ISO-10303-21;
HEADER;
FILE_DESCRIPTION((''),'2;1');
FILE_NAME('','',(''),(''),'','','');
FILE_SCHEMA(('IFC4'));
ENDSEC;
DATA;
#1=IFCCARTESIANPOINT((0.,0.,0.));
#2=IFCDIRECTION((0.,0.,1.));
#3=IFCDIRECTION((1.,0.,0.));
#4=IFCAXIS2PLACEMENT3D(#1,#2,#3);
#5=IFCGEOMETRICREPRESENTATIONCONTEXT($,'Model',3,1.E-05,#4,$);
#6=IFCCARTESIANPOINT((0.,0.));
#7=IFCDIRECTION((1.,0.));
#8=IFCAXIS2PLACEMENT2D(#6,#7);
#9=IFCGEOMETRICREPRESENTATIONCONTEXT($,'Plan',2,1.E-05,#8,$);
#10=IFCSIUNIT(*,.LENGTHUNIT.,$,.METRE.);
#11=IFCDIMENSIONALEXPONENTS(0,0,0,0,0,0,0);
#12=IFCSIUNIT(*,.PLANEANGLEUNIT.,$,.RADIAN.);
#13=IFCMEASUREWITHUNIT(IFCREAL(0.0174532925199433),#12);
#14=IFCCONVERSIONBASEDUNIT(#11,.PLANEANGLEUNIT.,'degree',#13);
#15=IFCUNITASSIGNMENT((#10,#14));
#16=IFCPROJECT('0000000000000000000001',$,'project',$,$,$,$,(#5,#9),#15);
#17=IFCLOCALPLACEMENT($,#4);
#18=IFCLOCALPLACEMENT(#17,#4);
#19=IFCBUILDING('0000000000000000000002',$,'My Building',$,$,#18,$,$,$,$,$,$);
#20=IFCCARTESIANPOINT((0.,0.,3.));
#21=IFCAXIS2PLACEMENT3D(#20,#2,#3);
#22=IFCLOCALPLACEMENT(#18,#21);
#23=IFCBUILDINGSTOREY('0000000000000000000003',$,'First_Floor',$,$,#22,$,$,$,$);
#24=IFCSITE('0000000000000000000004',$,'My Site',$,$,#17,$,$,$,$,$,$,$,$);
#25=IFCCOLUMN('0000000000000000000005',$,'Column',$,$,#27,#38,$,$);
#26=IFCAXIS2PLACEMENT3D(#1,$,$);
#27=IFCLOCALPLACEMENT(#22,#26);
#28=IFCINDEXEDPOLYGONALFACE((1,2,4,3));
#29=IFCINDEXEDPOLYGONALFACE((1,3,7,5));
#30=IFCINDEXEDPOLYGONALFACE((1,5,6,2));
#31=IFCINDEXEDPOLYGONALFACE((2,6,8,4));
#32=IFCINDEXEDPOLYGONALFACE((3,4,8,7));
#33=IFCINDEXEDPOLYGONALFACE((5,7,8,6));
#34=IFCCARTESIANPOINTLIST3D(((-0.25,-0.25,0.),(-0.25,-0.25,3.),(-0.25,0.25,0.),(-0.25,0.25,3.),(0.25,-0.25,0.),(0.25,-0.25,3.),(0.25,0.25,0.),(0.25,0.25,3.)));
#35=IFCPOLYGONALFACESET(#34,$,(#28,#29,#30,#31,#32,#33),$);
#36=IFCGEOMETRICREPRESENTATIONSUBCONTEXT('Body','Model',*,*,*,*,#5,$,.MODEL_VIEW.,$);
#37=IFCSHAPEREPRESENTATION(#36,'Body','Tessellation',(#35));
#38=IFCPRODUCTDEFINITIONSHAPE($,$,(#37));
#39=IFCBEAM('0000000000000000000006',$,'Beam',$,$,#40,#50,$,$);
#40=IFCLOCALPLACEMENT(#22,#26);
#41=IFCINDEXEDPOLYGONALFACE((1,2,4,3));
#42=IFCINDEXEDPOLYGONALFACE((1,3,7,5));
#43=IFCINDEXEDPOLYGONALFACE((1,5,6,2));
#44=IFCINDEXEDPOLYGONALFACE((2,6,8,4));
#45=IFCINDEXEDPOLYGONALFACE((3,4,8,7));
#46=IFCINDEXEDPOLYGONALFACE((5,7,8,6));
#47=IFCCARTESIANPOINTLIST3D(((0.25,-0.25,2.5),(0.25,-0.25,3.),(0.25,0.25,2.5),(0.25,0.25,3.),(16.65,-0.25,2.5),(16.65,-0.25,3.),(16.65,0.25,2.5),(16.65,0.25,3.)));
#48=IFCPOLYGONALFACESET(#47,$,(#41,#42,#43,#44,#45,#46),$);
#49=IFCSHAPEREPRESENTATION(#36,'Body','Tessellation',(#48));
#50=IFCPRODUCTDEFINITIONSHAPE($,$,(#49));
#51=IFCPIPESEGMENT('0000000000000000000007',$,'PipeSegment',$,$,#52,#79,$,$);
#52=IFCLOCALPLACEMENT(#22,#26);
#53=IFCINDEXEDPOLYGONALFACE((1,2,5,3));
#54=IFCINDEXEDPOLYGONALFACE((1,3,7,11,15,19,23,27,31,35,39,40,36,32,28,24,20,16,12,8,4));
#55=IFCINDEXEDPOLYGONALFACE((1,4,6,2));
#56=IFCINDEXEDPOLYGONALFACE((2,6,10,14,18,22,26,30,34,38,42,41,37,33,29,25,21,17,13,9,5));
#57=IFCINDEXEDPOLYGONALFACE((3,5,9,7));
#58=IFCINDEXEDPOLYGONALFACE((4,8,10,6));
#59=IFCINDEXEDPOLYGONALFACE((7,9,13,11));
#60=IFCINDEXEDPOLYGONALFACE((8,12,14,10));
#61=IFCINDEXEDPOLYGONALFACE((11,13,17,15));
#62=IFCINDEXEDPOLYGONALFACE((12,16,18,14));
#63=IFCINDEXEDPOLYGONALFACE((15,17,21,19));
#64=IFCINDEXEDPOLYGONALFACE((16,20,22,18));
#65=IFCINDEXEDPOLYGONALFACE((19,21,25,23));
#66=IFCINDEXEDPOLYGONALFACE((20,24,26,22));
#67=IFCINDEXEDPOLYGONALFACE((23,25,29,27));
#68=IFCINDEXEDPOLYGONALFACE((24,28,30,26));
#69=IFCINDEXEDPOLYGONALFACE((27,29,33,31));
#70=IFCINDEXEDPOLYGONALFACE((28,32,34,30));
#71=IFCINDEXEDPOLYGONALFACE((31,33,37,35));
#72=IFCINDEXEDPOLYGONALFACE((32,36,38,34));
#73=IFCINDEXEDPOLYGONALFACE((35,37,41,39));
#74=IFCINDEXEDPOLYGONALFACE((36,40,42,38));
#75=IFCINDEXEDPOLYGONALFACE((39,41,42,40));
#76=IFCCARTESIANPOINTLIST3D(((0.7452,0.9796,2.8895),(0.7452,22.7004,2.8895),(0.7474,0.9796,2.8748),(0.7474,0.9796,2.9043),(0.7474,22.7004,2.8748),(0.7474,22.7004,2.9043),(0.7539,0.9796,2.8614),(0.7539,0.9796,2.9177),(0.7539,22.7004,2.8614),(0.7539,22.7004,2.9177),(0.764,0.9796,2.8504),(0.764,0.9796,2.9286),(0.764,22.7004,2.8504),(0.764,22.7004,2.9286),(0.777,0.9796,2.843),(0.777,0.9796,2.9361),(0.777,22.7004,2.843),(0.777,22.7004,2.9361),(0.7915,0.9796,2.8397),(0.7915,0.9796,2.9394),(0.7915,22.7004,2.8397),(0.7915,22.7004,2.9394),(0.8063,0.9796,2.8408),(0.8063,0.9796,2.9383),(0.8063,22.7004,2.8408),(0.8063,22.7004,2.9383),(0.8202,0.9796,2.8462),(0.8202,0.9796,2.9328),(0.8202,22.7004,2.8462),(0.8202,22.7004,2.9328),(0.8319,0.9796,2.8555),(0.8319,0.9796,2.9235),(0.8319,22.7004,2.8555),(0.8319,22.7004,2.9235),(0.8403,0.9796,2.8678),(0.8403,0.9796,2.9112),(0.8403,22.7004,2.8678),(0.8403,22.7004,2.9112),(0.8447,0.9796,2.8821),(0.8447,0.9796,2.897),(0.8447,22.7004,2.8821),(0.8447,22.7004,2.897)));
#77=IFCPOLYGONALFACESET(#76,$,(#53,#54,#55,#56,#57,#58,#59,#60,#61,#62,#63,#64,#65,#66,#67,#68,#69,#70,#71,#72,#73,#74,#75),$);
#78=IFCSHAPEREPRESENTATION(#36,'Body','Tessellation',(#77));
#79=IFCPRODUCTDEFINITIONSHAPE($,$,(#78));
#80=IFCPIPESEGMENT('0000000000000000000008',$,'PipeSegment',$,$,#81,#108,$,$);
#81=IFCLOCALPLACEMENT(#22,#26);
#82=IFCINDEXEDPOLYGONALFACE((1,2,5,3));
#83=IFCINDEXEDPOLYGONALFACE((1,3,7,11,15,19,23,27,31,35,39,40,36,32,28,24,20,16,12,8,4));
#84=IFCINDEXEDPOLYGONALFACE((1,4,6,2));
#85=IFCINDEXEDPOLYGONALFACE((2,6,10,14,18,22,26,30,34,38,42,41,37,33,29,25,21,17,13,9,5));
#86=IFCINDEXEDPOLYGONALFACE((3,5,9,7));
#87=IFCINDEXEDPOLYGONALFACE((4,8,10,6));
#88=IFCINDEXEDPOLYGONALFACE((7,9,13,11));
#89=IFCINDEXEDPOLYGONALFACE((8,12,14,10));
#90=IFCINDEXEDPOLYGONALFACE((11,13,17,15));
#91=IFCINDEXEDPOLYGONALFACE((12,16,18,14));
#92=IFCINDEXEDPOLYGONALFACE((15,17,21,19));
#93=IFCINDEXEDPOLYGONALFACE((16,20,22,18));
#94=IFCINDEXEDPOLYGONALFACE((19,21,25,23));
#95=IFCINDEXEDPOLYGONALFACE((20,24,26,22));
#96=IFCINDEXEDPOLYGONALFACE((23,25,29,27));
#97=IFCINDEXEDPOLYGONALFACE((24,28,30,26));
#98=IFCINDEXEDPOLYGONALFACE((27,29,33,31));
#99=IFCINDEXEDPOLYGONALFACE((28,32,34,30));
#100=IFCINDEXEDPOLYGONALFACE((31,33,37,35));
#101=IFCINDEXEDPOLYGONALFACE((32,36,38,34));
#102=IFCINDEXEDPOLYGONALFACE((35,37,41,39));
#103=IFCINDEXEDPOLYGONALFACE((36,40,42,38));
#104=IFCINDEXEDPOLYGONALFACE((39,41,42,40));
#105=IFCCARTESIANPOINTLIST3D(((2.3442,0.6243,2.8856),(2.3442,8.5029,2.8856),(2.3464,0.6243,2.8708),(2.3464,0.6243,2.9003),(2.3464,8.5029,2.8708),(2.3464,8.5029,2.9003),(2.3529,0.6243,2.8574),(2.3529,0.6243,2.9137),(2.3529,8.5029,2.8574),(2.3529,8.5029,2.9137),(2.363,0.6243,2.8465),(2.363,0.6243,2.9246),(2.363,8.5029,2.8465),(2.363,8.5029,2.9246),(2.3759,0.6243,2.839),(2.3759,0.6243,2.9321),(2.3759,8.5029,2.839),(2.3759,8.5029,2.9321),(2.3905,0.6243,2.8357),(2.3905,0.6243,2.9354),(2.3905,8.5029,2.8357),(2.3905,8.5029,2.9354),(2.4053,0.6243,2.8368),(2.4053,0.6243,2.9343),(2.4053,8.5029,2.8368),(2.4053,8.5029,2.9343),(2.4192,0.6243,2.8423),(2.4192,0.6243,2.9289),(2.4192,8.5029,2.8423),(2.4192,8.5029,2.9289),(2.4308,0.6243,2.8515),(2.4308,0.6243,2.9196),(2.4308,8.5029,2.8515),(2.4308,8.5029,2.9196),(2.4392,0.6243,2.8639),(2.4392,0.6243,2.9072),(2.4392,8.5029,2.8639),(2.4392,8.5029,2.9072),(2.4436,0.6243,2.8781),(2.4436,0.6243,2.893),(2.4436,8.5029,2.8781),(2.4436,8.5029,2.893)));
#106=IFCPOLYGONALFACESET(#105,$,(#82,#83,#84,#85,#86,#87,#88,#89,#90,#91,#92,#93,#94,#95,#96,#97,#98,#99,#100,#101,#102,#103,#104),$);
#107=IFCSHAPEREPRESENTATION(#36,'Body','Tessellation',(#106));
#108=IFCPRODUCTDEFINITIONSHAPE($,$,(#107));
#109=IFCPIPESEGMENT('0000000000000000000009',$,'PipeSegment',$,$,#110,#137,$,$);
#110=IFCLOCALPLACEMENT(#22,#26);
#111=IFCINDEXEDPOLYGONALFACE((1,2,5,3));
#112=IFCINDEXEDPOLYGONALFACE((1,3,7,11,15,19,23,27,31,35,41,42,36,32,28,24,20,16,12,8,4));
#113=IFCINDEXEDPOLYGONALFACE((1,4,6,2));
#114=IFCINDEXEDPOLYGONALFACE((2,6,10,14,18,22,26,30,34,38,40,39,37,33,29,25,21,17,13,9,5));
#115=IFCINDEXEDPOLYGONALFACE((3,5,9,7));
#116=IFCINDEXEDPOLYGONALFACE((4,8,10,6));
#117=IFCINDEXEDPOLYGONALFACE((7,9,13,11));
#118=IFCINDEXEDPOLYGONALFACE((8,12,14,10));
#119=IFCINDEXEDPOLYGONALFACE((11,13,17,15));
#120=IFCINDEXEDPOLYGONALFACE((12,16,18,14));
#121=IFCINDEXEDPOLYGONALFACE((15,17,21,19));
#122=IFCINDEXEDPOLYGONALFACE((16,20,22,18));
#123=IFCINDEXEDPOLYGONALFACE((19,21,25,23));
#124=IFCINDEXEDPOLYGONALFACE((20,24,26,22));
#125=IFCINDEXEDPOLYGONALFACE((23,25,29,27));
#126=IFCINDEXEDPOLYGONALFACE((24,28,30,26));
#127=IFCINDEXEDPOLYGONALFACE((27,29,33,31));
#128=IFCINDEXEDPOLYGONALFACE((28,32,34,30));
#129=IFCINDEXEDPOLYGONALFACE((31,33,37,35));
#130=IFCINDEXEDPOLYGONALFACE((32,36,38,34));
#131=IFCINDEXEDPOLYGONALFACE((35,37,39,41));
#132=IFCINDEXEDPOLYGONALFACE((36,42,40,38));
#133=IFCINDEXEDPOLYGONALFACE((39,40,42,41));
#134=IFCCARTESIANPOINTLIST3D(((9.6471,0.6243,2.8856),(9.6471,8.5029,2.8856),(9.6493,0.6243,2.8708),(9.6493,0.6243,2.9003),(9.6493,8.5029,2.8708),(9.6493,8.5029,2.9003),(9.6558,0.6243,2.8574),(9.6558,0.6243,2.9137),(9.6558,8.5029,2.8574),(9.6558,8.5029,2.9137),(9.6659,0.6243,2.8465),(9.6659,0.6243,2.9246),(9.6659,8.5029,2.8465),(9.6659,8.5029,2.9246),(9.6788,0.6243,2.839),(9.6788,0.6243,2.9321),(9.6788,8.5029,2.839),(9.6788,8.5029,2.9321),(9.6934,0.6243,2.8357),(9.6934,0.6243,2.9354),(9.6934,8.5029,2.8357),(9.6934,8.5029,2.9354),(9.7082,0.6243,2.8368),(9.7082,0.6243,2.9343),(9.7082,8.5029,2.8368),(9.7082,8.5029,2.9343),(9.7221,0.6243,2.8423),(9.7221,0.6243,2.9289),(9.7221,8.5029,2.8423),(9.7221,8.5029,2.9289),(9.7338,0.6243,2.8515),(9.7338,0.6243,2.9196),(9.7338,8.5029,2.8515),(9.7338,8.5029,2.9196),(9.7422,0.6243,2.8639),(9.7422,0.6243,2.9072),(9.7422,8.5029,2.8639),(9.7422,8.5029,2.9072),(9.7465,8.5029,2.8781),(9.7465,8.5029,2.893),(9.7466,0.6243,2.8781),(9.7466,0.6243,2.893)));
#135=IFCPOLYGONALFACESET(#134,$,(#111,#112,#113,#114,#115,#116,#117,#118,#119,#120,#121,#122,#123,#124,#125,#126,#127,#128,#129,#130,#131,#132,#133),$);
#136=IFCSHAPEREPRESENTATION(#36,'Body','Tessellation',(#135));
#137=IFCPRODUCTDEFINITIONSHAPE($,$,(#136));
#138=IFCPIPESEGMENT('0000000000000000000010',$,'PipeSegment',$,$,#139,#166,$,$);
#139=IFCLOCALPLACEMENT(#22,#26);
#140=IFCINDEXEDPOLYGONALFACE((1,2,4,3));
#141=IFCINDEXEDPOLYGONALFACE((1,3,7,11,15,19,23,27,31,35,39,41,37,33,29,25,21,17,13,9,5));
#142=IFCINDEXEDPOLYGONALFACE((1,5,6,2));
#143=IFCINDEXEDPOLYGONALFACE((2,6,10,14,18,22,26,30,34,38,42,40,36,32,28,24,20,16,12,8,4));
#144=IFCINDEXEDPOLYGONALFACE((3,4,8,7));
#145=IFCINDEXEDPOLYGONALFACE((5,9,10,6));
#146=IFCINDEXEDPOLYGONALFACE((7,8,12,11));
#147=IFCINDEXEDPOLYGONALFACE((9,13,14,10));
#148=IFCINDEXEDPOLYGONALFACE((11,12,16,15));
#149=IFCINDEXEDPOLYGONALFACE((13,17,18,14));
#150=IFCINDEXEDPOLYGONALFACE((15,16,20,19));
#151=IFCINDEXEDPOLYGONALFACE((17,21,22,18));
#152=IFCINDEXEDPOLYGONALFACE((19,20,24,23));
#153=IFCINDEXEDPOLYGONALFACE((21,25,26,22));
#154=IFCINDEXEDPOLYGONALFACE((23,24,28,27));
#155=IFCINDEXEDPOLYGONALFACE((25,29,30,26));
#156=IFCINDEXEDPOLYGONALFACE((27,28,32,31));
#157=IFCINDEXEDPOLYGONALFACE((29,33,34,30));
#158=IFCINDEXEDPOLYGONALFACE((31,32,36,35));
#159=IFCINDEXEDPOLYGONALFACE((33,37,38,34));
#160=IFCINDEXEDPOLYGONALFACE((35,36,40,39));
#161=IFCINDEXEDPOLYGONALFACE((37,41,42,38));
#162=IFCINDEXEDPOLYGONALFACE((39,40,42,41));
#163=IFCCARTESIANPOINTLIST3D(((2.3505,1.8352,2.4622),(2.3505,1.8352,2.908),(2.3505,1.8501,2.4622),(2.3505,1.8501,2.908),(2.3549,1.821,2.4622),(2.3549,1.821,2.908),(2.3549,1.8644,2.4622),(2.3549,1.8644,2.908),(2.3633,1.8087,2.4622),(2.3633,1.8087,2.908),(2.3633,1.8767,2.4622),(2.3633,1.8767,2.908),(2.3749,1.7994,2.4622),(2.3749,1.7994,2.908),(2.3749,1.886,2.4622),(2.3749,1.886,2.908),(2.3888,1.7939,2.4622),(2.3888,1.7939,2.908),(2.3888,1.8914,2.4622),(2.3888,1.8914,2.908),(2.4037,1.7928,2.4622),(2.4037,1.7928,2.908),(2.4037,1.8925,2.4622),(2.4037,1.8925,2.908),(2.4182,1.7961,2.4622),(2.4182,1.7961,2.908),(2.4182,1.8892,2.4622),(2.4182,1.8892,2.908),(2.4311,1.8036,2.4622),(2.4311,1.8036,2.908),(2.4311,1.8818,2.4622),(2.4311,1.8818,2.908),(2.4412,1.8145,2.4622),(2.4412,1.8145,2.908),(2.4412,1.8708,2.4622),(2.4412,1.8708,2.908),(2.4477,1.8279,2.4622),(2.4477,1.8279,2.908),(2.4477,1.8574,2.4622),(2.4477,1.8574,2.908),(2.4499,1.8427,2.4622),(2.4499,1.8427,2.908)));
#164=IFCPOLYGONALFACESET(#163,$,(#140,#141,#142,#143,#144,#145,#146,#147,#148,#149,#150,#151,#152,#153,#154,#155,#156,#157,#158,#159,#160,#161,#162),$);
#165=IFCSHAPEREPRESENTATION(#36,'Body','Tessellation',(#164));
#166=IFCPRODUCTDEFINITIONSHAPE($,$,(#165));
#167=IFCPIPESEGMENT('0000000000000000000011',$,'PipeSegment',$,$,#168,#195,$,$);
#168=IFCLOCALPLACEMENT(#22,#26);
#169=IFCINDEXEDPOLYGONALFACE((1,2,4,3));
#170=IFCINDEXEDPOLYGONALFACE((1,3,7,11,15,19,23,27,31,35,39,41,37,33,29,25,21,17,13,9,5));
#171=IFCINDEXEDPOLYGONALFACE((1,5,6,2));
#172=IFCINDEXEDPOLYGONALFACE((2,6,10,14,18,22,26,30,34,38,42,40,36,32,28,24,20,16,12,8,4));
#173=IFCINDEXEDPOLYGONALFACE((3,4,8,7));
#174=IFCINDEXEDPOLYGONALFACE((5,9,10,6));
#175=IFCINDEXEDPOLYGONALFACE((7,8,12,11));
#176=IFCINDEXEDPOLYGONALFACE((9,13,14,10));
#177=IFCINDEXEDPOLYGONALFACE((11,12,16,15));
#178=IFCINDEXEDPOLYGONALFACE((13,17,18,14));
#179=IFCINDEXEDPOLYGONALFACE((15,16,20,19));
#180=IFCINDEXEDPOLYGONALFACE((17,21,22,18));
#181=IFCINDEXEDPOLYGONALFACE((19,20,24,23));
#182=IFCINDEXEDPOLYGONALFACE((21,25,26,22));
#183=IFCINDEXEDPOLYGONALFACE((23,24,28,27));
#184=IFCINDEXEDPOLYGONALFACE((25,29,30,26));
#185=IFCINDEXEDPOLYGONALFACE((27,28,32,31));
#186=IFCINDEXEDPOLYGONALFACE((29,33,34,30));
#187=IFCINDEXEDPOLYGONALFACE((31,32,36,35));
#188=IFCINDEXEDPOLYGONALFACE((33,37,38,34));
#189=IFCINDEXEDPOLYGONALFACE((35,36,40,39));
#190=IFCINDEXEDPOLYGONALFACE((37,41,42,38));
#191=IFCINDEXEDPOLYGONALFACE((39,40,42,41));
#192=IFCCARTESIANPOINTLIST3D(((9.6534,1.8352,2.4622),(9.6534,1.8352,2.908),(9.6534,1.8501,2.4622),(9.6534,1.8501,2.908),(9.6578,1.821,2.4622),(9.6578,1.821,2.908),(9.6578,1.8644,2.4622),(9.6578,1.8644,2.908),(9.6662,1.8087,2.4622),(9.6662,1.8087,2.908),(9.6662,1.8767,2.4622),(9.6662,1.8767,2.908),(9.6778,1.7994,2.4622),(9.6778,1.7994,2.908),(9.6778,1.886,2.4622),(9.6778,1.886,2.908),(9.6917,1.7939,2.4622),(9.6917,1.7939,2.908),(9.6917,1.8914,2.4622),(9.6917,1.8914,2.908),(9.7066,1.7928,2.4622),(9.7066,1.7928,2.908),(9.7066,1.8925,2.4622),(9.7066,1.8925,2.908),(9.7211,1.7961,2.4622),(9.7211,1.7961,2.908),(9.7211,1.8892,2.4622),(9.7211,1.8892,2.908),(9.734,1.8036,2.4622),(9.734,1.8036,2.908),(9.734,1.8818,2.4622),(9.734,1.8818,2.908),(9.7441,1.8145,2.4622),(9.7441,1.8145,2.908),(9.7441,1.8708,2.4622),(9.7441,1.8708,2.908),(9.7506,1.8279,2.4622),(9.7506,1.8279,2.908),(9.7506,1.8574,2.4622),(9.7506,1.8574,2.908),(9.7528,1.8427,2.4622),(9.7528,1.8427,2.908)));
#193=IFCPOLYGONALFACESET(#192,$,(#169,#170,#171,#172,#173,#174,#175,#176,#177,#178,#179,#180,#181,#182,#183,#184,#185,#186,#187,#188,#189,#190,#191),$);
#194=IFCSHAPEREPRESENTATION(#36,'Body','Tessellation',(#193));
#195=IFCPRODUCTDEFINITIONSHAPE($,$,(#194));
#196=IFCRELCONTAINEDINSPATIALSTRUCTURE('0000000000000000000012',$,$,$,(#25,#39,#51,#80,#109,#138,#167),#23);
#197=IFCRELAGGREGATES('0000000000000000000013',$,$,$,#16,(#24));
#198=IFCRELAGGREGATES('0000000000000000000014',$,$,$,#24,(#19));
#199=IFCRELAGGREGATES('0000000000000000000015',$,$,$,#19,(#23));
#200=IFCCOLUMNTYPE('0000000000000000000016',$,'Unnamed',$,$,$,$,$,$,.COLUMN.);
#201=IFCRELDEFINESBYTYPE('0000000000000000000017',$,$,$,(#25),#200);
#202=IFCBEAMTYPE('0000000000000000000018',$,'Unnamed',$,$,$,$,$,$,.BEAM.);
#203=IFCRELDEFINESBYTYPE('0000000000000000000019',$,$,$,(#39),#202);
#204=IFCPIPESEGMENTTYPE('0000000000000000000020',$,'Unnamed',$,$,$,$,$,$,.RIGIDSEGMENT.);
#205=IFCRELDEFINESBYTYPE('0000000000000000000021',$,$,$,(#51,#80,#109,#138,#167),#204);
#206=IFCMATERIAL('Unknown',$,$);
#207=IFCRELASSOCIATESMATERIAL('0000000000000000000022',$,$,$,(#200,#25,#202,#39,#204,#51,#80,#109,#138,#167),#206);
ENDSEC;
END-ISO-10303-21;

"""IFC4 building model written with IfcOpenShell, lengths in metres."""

from ifc_helpers import new_model, entity, si_unit, converted_unit, frame, origin_with_axes, origin_2d_with_axis, place, context, subcontext, project, spatial, rectangle, circle, extrude, material, material_profile, profile_set, profile_usage, type_object, element, save


model = new_model("IFC4")

# Units and contexts
model_context = context("Model", 3, precision=1e-05, world=origin_with_axes())
plan_context = context("Plan", 2, precision=1e-05, world=origin_2d_with_axis())
body_context = subcontext(model_context, "Body", "Model", "MODEL_VIEW")
ifc_project = project(units=[si_unit("LENGTHUNIT", "METRE"), converted_unit("PLANEANGLEUNIT", "degree", entity("IfcReal", 0.0174532925199433), si_unit("PLANEANGLEUNIT", "RADIAN"), dimensions=[0, 0, 0, 0, 0, 0, 0])], contexts=[model_context, plan_context])

# Site, building, storey
site_placement = place(None, origin_with_axes())
site = spatial("IfcSite", under=ifc_project, at=site_placement, Name="My Site")
building_placement = place(site_placement, origin_with_axes())
building = spatial("IfcBuilding", under=site, at=building_placement, Name="My Building")
storey_placement = place(building_placement, frame((0.0, 0.0, 3.0), z_axis=(0.0, 0.0, 1.0), x_axis=(1.0, 0.0, 0.0)))
storey = spatial("IfcBuildingStorey", under=building, at=storey_placement, Name="First_Floor")

# Column
ifc_material = material(Name="Unknown")
ifc_material_profile_1 = material_profile(ifc_material, rectangle(XDim=0.5, YDim=0.5))
ifc_profile_set_1 = profile_set([ifc_material_profile_1])
ifc_profile_usage_1 = profile_usage(ifc_profile_set_1, cardinal=5)
column_type = type_object("IfcColumnType", Name="Unnamed", PredefinedType="COLUMN", material=ifc_profile_set_1)
column_placement = place(storey_placement, frame((0.0, 0.0, 0.0), z_axis=(0.0, 0.0, 1.0), x_axis=(1.0, 0.0, 0.0)))
element("IfcColumn", 1, at=column_placement, inside=storey, type_object=column_type, material=ifc_profile_usage_1, Name="Column", context=body_context, shape_type="SweptSolid", body=[
    extrude(rectangle(XDim=0.5, YDim=0.5), origin_with_axes(), (0.0, 0.0, 1.0), 3.0),
])

# Beam
ifc_material_profile_2 = material_profile(ifc_material, rectangle(XDim=0.5, YDim=0.5))
ifc_profile_set_2 = profile_set([ifc_material_profile_2])
ifc_profile_usage_2 = profile_usage(ifc_profile_set_2, cardinal=6)
beam_type = type_object("IfcBeamType", Name="Unnamed", PredefinedType="BEAM", material=ifc_profile_set_2)
beam_placement = place(storey_placement, frame((0.25, -0.25, 2.75), z_axis=(1.0, 0.0, 0.0), x_axis=(0.0, 1.0, 0.0)))
element("IfcBeam", 2, at=beam_placement, inside=storey, type_object=beam_type, material=ifc_profile_usage_2, Name="Beam", context=body_context, shape_type="SweptSolid", body=[
    extrude(rectangle(XDim=0.5, YDim=0.5), frame((0.25, 0.0, 0.0), z_axis=(0.0, 0.0, 1.0), x_axis=(1.0, 0.0, 0.0)), (0.0, 0.0, 1.0), 16.4),
])

# Pipe segments
ifc_material_profile_3 = material_profile(ifc_material, circle(Radius=0.05))
ifc_profile_set_3 = profile_set([ifc_material_profile_3])
ifc_profile_usage_3 = profile_usage(ifc_profile_set_3, cardinal=5)
pipe_segment_type = type_object("IfcPipeSegmentType", Name="Unnamed", PredefinedType="RIGIDSEGMENT", material=ifc_profile_set_3)
pipe_segment_1_placement = place(storey_placement, frame((0.7952, 0.9796, 2.8895), z_axis=(0.0, 1.0, 0.0), x_axis=(-1.0, 0.0, 0.0)))
element("IfcPipeSegment", 3, at=pipe_segment_1_placement, inside=storey, type_object=pipe_segment_type, material=ifc_profile_usage_3, Name="PipeSegment", context=body_context, shape_type="SweptSolid", body=[
    extrude(circle(Radius=0.05), origin_with_axes(), (0.0, 0.0, 1.0), 21.7208),
])
ifc_profile_usage_4 = profile_usage(ifc_profile_set_3, cardinal=5)
pipe_segment_2_placement = place(storey_placement, frame((2.3942, 0.6243, 2.8856), z_axis=(0.0, 1.0, 0.0), x_axis=(-1.0, 0.0, 0.0)))
element("IfcPipeSegment", 4, at=pipe_segment_2_placement, inside=storey, type_object=pipe_segment_type, material=ifc_profile_usage_4, Name="PipeSegment", context=body_context, shape_type="SweptSolid", body=[
    extrude(circle(Radius=0.05), origin_with_axes(), (0.0, 0.0, 1.0), 7.8786),
])
ifc_profile_usage_5 = profile_usage(ifc_profile_set_3, cardinal=5)
pipe_segment_3_placement = place(storey_placement, frame((9.6971, 0.6243, 2.8856), z_axis=(0.0, 1.0, 0.0), x_axis=(-1.0, 0.0, 0.0)))
element("IfcPipeSegment", 5, at=pipe_segment_3_placement, inside=storey, type_object=pipe_segment_type, material=ifc_profile_usage_5, Name="PipeSegment", context=body_context, shape_type="SweptSolid", body=[
    extrude(circle(Radius=0.05), origin_with_axes(), (0.0, 0.0, 1.0), 7.8786),
])
ifc_profile_usage_6 = profile_usage(ifc_profile_set_3, cardinal=5)
pipe_segment_4_placement = place(storey_placement, frame((2.3999, 1.8427, 2.908), z_axis=(0.0, 0.0, -1.0), x_axis=(1.0, 0.0, 0.0)))
element("IfcPipeSegment", 6, at=pipe_segment_4_placement, inside=storey, type_object=pipe_segment_type, material=ifc_profile_usage_6, Name="PipeSegment", context=body_context, shape_type="SweptSolid", body=[
    extrude(circle(Radius=0.05), origin_with_axes(), (0.0, 0.0, 1.0), 0.4458),
])
ifc_profile_usage_7 = profile_usage(ifc_profile_set_3, cardinal=5)
pipe_segment_5_placement = place(storey_placement, frame((9.7028, 1.8427, 2.908), z_axis=(0.0, 0.0, -1.0), x_axis=(1.0, 0.0, 0.0)))
element("IfcPipeSegment", 7, at=pipe_segment_5_placement, inside=storey, type_object=pipe_segment_type, material=ifc_profile_usage_7, Name="PipeSegment", context=body_context, shape_type="SweptSolid", body=[
    extrude(circle(Radius=0.05), origin_with_axes(), (0.0, 0.0, 1.0), 0.4458),
])

save(model, "model.ifc")
